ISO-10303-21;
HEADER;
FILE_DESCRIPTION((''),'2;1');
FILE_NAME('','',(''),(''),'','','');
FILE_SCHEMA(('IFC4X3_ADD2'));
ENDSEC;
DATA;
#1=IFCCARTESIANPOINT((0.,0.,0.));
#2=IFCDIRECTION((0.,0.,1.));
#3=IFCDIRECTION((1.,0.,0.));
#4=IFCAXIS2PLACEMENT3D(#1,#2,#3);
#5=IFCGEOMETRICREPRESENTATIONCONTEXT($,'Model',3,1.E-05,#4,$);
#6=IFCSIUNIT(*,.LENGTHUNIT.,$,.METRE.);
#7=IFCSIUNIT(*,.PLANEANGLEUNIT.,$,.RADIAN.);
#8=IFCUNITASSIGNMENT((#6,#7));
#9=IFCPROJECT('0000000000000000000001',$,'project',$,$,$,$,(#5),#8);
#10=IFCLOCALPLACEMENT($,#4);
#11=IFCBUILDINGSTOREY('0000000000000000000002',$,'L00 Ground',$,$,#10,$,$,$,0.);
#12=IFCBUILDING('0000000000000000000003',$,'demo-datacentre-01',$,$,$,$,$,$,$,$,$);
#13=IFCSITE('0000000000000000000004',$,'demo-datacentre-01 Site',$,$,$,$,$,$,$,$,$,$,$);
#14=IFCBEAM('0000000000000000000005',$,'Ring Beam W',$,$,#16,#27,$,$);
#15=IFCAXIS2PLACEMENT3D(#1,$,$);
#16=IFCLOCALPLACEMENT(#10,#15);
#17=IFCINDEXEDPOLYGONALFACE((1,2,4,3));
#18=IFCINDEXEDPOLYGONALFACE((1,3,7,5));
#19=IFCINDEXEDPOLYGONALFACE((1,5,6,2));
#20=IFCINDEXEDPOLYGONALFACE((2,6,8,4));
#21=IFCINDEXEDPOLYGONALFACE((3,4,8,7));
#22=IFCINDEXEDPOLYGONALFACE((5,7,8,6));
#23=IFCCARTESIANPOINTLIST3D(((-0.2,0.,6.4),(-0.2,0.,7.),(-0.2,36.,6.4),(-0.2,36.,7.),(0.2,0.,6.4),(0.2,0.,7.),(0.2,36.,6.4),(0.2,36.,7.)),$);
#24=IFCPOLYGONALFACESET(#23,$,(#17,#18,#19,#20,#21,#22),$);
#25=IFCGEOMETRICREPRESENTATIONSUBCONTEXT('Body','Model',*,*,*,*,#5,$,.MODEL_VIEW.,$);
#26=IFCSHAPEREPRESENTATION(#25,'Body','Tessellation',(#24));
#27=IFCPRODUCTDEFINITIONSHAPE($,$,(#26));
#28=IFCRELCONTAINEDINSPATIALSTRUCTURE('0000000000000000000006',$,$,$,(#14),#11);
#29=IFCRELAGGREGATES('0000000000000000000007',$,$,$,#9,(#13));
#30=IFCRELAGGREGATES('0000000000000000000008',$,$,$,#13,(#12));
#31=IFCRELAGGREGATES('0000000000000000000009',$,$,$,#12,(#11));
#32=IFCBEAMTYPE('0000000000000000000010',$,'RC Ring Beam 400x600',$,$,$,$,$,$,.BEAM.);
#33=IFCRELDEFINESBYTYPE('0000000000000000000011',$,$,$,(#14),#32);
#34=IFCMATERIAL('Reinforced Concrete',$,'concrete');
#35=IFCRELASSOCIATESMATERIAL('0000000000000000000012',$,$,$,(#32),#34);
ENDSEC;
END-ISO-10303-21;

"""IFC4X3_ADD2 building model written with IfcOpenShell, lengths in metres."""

from ifc_helpers import new_model, si_unit, frame, origin_with_axes, place, context, subcontext, project, spatial, rectangle, extrude, material, type_object, element, save


model = new_model("IFC4X3_ADD2")

# Units and contexts
model_context = context("Model", 3, precision=1e-05, world=origin_with_axes())
body_context = subcontext(model_context, "Body", "Model", "MODEL_VIEW")
ifc_project = project(units=[si_unit("LENGTHUNIT", "METRE"), si_unit("PLANEANGLEUNIT", "RADIAN")], contexts=[model_context])

# Site, building, storey
site = spatial("IfcSite", under=ifc_project, Name="demo-datacentre-01 Site")
building = spatial("IfcBuilding", under=site, Name="demo-datacentre-01")
storey_placement = place(None, origin_with_axes())
storey = spatial("IfcBuildingStorey", under=building, at=storey_placement, Name="L00 Ground", Elevation=0.0)

# Shared definitions
ifc_material = material(Name="Reinforced Concrete", Category="concrete")

# Beam
beam_type = type_object("IfcBeamType", Name="RC Ring Beam 400x600", PredefinedType="BEAM", material=ifc_material)
beam_1_placement = place(storey_placement, frame((0.0, 0.0, 6.7), z_axis=(0.0, 1.0, 0.0), x_axis=(-1.0, 0.0, 0.0)))
element("IfcBeam", 1, at=beam_1_placement, inside=storey, type_object=beam_type, Name="Ring Beam W", context=body_context, shape_type="SweptSolid", body=[
    extrude(rectangle(XDim=0.4, YDim=0.6), origin_with_axes(), (0.0, 0.0, 1.0), 36.0),
])

save(model, "model.ifc")
